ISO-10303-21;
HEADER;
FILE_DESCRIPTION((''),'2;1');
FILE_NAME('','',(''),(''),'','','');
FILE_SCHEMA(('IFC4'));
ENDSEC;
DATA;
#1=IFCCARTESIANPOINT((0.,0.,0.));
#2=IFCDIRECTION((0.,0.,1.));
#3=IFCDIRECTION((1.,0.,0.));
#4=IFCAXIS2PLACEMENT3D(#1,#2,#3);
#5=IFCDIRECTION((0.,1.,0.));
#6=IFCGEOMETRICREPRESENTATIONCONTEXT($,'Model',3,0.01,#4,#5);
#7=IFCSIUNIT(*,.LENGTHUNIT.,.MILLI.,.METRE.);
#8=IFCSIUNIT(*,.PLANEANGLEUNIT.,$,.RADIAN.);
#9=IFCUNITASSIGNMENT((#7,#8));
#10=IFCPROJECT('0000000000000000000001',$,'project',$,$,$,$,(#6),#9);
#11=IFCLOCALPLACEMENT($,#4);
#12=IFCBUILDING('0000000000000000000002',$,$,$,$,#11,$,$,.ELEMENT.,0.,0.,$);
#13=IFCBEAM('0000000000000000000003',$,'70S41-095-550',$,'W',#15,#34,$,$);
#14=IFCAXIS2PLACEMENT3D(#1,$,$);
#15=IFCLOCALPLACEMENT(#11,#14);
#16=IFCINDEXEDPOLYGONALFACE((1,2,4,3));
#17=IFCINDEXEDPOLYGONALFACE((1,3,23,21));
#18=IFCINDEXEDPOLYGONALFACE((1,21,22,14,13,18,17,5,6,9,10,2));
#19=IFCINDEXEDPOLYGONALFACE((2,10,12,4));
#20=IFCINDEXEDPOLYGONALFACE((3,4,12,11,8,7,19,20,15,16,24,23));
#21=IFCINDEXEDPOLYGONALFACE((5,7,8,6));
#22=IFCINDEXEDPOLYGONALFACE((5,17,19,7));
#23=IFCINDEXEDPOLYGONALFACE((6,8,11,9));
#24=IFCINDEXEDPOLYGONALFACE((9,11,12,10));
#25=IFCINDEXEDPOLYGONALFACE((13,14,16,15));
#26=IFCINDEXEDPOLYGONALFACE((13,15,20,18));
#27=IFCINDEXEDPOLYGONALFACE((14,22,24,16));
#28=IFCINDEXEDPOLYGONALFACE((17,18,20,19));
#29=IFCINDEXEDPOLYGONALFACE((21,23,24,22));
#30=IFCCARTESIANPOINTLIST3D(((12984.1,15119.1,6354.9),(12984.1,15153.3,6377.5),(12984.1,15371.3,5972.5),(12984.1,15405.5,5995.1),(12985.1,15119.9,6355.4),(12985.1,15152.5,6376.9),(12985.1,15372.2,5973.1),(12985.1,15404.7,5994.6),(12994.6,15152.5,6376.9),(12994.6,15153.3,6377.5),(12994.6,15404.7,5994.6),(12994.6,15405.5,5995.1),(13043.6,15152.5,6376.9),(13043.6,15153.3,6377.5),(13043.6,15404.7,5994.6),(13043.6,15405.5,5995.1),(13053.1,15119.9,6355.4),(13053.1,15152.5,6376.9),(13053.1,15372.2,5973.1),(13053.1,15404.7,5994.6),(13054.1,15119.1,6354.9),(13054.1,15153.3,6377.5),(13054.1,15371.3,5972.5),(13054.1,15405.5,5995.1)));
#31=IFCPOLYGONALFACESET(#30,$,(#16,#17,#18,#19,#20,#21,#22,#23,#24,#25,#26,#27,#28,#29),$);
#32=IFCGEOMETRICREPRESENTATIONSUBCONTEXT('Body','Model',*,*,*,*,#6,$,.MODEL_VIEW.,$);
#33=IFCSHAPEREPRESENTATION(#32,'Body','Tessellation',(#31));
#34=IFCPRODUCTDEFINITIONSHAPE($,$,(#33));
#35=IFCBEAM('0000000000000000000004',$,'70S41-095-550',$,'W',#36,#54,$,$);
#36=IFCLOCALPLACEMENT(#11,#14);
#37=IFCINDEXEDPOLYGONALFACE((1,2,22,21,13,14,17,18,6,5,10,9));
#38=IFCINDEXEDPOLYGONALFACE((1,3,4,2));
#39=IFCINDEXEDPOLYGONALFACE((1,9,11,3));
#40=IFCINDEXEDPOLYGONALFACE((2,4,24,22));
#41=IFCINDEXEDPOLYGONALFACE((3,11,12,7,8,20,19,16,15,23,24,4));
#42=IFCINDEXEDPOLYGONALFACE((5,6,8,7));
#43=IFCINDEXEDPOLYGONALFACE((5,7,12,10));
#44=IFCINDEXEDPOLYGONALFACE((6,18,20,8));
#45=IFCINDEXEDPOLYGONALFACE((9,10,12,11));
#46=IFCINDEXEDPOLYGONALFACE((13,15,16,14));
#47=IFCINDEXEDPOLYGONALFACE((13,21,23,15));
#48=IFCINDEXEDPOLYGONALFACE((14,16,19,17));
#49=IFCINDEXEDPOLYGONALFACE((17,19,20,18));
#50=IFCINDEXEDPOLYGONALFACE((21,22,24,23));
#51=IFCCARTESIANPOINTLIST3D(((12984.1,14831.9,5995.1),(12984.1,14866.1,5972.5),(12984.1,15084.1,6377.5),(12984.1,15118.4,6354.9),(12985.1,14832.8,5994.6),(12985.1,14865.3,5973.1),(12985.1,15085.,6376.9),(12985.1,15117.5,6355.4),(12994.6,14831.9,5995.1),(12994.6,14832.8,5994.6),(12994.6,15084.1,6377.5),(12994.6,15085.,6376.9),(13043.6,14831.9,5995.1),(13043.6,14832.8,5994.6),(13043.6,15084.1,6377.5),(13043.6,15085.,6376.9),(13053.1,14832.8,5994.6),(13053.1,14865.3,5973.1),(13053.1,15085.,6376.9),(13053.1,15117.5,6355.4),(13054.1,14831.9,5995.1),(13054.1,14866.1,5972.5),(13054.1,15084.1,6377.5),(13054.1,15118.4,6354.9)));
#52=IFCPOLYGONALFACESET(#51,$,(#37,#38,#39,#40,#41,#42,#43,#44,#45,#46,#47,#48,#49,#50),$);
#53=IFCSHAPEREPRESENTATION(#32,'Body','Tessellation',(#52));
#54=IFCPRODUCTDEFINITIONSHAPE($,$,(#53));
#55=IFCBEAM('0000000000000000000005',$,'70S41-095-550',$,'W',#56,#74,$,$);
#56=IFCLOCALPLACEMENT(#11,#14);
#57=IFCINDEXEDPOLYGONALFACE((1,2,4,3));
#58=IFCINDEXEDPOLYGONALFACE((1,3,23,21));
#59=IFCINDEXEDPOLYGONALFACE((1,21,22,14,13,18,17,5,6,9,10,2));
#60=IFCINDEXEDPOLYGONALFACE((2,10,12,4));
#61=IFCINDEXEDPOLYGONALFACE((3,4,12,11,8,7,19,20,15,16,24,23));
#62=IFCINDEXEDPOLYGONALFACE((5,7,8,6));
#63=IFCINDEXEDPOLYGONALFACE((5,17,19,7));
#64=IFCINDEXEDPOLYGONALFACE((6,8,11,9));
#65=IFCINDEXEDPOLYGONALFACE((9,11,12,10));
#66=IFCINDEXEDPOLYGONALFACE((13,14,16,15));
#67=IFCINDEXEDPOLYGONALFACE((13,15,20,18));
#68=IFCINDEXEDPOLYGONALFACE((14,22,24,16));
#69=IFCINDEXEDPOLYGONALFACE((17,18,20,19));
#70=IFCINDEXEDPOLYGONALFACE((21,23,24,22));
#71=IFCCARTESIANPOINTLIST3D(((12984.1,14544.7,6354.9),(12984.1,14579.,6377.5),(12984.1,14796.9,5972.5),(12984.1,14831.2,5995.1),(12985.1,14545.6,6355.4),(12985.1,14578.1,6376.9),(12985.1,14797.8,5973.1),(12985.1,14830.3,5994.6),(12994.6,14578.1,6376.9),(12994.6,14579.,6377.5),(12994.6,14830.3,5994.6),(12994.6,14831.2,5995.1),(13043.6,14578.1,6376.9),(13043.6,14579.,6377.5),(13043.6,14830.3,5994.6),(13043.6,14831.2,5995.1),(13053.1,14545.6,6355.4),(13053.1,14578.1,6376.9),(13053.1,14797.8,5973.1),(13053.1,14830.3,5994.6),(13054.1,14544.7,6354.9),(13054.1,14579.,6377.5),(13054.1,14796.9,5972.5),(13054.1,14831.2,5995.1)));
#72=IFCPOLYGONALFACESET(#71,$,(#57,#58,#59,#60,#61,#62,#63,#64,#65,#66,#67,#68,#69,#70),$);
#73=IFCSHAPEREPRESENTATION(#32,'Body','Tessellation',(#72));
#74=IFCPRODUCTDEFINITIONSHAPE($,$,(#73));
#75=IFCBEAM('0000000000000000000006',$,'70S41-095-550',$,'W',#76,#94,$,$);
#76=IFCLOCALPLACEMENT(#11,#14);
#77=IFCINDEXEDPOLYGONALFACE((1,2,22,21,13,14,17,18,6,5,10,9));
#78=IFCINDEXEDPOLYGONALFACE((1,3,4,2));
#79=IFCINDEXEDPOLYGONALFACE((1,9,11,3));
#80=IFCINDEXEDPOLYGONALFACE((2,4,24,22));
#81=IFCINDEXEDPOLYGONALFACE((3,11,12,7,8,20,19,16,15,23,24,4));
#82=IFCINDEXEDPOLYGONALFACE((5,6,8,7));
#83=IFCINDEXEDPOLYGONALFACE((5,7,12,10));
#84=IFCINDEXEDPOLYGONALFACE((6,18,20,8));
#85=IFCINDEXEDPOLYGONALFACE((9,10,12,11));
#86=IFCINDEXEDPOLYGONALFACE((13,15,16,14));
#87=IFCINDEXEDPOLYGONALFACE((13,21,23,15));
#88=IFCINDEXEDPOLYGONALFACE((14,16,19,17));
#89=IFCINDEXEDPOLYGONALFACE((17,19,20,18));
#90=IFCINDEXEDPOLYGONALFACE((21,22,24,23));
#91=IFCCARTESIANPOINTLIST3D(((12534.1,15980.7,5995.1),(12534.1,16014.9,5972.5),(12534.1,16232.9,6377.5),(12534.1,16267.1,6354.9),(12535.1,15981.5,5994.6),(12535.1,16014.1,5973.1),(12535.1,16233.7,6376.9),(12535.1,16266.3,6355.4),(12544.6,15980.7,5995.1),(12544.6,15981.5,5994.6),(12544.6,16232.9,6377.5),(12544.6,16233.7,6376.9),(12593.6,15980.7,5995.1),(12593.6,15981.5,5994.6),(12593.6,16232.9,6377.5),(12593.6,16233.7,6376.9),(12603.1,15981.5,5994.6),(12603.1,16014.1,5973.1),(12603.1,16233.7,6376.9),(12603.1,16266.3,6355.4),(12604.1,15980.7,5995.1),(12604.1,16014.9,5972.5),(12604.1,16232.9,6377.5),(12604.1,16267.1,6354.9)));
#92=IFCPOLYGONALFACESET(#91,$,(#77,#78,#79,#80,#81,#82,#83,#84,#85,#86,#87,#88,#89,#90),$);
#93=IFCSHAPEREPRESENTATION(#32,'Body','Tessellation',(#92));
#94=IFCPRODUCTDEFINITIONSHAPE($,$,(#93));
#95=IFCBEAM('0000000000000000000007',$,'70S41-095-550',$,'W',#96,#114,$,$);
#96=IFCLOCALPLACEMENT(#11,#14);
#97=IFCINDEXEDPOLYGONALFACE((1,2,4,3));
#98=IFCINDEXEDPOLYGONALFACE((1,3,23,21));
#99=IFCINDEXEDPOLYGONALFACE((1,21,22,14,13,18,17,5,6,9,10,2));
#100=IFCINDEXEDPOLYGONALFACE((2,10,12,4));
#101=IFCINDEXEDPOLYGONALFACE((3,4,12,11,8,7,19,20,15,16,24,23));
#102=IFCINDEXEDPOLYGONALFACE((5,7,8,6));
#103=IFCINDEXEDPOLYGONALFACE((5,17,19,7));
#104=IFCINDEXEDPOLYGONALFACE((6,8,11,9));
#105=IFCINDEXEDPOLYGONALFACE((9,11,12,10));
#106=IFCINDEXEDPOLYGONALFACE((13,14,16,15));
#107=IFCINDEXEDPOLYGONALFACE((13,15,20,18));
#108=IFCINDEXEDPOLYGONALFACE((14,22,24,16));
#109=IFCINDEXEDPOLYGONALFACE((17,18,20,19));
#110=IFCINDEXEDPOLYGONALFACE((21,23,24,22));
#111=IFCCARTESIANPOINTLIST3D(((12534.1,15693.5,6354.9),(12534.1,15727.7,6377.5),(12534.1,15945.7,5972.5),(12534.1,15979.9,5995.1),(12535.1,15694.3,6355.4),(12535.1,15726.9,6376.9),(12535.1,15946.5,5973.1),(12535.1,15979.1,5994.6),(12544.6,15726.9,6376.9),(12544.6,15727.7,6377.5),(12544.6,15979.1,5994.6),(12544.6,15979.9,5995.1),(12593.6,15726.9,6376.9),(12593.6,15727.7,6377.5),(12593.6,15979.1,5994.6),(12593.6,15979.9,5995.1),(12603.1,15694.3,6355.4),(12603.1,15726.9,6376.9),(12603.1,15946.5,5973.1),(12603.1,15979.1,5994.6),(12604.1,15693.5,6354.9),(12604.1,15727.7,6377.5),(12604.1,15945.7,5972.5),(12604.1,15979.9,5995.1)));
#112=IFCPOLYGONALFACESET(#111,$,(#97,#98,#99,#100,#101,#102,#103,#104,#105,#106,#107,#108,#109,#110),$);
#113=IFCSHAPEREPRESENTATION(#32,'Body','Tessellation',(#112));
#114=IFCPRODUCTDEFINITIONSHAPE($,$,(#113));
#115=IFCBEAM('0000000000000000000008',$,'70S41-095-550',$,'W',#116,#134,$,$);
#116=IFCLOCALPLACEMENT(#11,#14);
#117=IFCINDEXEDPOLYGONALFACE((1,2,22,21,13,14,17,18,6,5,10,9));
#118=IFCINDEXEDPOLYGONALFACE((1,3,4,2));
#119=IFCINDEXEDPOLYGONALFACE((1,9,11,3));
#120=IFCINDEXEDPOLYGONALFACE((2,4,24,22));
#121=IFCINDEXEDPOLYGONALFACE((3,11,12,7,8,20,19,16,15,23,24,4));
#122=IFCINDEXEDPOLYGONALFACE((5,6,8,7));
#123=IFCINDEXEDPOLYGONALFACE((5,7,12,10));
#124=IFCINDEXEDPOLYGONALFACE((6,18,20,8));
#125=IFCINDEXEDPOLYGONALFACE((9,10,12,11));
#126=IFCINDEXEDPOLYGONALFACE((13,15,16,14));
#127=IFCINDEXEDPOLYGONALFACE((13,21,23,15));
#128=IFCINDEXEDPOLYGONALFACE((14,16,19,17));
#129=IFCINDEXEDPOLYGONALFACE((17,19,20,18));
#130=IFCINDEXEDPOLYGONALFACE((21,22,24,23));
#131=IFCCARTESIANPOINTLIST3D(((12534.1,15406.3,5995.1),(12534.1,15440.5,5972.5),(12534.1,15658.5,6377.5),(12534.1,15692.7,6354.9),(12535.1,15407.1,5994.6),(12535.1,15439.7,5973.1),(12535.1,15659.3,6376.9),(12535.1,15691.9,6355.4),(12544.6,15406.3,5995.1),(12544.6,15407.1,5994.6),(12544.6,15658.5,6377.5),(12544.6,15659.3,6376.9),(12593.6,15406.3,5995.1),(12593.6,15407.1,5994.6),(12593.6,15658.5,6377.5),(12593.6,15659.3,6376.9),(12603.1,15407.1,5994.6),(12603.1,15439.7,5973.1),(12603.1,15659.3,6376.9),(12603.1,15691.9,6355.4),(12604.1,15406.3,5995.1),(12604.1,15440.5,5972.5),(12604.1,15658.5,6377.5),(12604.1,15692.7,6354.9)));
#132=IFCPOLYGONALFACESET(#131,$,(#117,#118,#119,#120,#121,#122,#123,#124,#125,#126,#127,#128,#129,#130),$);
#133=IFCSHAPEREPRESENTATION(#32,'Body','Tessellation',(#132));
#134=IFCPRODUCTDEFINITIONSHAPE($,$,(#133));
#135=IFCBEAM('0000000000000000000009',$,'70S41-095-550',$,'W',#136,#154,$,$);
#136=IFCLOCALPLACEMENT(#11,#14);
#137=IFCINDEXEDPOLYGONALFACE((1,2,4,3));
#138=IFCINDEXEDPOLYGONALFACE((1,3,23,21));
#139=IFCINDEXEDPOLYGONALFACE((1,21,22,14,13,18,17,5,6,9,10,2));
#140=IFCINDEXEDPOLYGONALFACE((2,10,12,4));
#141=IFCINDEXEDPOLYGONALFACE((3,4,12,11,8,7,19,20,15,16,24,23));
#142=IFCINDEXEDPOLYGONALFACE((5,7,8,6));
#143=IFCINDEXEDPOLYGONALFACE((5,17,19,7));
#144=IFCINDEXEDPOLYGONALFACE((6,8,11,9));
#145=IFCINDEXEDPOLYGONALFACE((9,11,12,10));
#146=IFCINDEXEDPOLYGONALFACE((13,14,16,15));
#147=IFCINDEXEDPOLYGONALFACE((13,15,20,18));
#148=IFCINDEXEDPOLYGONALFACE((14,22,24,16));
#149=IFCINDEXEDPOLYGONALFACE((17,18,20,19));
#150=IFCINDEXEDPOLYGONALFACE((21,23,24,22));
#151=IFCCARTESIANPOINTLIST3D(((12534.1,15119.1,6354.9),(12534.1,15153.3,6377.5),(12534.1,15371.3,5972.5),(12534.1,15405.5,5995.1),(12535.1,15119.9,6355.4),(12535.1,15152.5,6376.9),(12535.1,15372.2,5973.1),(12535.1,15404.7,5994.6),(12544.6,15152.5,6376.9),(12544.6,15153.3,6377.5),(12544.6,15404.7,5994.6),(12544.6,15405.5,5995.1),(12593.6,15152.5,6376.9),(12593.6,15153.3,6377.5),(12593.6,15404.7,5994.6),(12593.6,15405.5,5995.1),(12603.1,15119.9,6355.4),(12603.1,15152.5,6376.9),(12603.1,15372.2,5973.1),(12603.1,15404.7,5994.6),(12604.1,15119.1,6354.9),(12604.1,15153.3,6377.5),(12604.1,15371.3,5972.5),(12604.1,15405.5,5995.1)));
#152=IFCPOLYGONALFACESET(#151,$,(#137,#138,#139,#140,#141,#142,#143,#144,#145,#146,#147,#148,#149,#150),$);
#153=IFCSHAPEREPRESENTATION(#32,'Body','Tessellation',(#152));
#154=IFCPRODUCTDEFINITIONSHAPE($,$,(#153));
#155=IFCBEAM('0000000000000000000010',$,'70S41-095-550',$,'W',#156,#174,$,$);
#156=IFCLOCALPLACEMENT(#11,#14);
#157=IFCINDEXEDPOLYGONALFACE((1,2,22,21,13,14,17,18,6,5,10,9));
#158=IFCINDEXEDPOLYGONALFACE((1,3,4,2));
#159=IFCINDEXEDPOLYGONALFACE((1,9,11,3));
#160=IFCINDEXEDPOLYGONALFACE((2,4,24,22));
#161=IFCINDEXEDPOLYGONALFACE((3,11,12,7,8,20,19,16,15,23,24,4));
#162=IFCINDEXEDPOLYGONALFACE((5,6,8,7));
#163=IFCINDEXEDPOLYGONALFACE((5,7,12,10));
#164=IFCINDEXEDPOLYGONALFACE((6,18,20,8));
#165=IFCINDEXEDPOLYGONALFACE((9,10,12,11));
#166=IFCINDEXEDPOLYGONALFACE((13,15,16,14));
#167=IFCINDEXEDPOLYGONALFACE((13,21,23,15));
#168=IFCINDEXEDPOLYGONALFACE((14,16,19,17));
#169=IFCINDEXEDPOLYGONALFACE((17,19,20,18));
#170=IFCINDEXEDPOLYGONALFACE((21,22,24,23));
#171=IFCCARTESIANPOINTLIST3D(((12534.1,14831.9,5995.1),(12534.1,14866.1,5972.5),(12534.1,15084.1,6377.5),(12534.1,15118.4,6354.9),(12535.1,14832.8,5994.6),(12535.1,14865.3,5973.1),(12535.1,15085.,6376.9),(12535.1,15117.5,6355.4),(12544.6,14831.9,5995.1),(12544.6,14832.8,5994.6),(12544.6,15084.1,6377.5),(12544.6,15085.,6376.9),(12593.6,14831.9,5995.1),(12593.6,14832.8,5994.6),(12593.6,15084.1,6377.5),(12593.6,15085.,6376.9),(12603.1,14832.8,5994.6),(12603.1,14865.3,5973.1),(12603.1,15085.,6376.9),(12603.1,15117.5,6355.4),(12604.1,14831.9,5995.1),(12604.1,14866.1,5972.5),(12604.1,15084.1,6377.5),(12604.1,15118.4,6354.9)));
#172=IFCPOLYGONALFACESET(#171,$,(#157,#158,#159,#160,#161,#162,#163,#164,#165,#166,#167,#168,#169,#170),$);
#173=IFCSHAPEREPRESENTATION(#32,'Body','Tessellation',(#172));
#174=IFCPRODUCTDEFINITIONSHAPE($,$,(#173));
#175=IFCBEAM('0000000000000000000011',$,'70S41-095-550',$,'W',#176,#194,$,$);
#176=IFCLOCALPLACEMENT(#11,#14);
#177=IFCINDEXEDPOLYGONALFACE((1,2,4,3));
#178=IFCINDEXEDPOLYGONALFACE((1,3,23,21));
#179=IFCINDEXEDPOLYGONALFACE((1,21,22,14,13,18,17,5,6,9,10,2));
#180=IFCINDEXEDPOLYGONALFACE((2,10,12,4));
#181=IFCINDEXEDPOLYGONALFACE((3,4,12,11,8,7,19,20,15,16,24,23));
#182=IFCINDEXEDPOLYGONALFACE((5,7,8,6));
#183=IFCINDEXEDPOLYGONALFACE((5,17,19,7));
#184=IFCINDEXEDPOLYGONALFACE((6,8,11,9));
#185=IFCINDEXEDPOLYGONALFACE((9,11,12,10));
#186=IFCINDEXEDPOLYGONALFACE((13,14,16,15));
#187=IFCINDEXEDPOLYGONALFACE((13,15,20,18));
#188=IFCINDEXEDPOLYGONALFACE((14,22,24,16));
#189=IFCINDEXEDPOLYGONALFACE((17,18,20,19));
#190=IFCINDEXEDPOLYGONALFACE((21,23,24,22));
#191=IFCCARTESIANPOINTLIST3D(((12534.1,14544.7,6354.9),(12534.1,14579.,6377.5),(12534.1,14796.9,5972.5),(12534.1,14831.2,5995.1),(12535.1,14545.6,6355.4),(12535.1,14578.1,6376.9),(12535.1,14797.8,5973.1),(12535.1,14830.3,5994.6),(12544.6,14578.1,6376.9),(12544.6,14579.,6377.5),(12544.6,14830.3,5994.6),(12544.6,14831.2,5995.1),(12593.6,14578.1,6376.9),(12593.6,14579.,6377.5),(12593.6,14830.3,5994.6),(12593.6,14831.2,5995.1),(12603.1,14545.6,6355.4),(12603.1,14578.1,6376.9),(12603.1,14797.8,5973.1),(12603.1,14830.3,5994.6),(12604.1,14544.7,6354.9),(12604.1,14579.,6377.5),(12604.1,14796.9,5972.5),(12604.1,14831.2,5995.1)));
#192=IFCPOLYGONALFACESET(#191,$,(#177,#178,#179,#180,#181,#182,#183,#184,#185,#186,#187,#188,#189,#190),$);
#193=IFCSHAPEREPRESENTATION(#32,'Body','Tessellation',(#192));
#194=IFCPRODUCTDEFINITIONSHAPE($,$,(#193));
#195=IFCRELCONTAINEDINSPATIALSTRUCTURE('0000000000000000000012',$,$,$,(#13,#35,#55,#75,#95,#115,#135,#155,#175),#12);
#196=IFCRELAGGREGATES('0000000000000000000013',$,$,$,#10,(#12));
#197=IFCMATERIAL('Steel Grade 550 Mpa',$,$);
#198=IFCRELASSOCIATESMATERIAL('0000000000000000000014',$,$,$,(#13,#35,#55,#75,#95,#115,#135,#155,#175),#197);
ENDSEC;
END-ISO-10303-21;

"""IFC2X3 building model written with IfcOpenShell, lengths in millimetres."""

from ifc_helpers import new_model, si_unit, direction, frame, origin, origin_with_axes, origin_2d_with_axis, place, context, subcontext, project, spatial, c_section, extrude, source, transform, mapped, material, element, save


model = new_model("IFC2X3")

# Units and contexts
model_context = context("Model", 3, precision=0.01, world=origin_with_axes(), true_north=direction((0.0, 1.0, 0.0)))
body_context = subcontext(model_context, "Body", "Model", "MODEL_VIEW")
ifc_project = project(units=[si_unit("LENGTHUNIT", "METRE", prefix="MILLI"), si_unit("PLANEANGLEUNIT", "RADIAN")], contexts=[model_context])

# Building
building_placement = place(None, origin_with_axes())
building = spatial("IfcBuilding", under=ifc_project, at=building_placement, CompositionType="ELEMENT", ElevationOfRefHeight=0.0, ElevationOfTerrain=0.0)

# Beams
ifc_material = material(Name="Steel Grade 550 Mpa")
shared_shape_1 = source(origin(), body_context, "Body", "SweptSolid", [
    extrude(c_section(Depth=70.0, Width=41.0, WallThickness=1.0, Girth=10.5, at=origin_2d_with_axis()), origin_with_axes(), (0.0, 0.0, 1.0), 458.1),
])
beam_1_placement = place(None, frame((13019.1, 15136.2, 6366.2), z_axis=(0.0, 0.550611, -0.834762), x_axis=(0.0, 0.834762, 0.550611)))
element("IfcBeam", 1, at=beam_1_placement, inside=building, material=ifc_material, Name="70S41-095-550", ObjectType="W", context=body_context, shape_type="MappedRepresentation", body=[
    mapped(shared_shape_1, transform((0.0, 0.0, 0.0), scale=1.0)),
])
shared_shape_2 = source(origin(), body_context, "Body", "SweptSolid", [
    extrude(c_section(Depth=70.0, Width=41.0, WallThickness=1.0, Girth=10.5, at=origin_2d_with_axis()), origin_with_axes(), (0.0, 0.0, 1.0), 458.1),
])
beam_2_placement = place(None, frame((13019.1, 14849.0, 5983.8), z_axis=(0.0, 0.550611, 0.834762), x_axis=(0.0, -0.834762, 0.550611)))
element("IfcBeam", 2, at=beam_2_placement, inside=building, material=ifc_material, Name="70S41-095-550", ObjectType="W", context=body_context, shape_type="MappedRepresentation", body=[
    mapped(shared_shape_2, transform((0.0, 0.0, 0.0), scale=1.0)),
])
shared_shape_3 = source(origin(), body_context, "Body", "SweptSolid", [
    extrude(c_section(Depth=70.0, Width=41.0, WallThickness=1.0, Girth=10.5, at=origin_2d_with_axis()), origin_with_axes(), (0.0, 0.0, 1.0), 458.1),
])
beam_3_placement = place(None, frame((13019.1, 14561.8, 6366.2), z_axis=(0.0, 0.550611, -0.834762), x_axis=(0.0, 0.834762, 0.550611)))
element("IfcBeam", 3, at=beam_3_placement, inside=building, material=ifc_material, Name="70S41-095-550", ObjectType="W", context=body_context, shape_type="MappedRepresentation", body=[
    mapped(shared_shape_3, transform((0.0, 0.0, 0.0), scale=1.0)),
])
shared_shape_4 = source(origin(), body_context, "Body", "SweptSolid", [
    extrude(c_section(Depth=70.0, Width=41.0, WallThickness=1.0, Girth=10.5, at=origin_2d_with_axis()), origin_with_axes(), (0.0, 0.0, 1.0), 458.1),
])
beam_4_placement = place(None, frame((12569.1, 15997.8, 5983.8), z_axis=(0.0, 0.550611, 0.834762), x_axis=(0.0, -0.834762, 0.550611)))
element("IfcBeam", 4, at=beam_4_placement, inside=building, material=ifc_material, Name="70S41-095-550", ObjectType="W", context=body_context, shape_type="MappedRepresentation", body=[
    mapped(shared_shape_4, transform((0.0, 0.0, 0.0), scale=1.0)),
])
shared_shape_5 = source(origin(), body_context, "Body", "SweptSolid", [
    extrude(c_section(Depth=70.0, Width=41.0, WallThickness=1.0, Girth=10.5, at=origin_2d_with_axis()), origin_with_axes(), (0.0, 0.0, 1.0), 458.1),
])
beam_5_placement = place(None, frame((12569.1, 15710.6, 6366.2), z_axis=(0.0, 0.550611, -0.834762), x_axis=(0.0, 0.834762, 0.550611)))
element("IfcBeam", 5, at=beam_5_placement, inside=building, material=ifc_material, Name="70S41-095-550", ObjectType="W", context=body_context, shape_type="MappedRepresentation", body=[
    mapped(shared_shape_5, transform((0.0, 0.0, 0.0), scale=1.0)),
])
shared_shape_6 = source(origin(), body_context, "Body", "SweptSolid", [
    extrude(c_section(Depth=70.0, Width=41.0, WallThickness=1.0, Girth=10.5, at=origin_2d_with_axis()), origin_with_axes(), (0.0, 0.0, 1.0), 458.1),
])
beam_6_placement = place(None, frame((12569.1, 15423.4, 5983.8), z_axis=(0.0, 0.550611, 0.834762), x_axis=(0.0, -0.834762, 0.550611)))
element("IfcBeam", 6, at=beam_6_placement, inside=building, material=ifc_material, Name="70S41-095-550", ObjectType="W", context=body_context, shape_type="MappedRepresentation", body=[
    mapped(shared_shape_6, transform((0.0, 0.0, 0.0), scale=1.0)),
])
shared_shape_7 = source(origin(), body_context, "Body", "SweptSolid", [
    extrude(c_section(Depth=70.0, Width=41.0, WallThickness=1.0, Girth=10.5, at=origin_2d_with_axis()), origin_with_axes(), (0.0, 0.0, 1.0), 458.1),
])
beam_7_placement = place(None, frame((12569.1, 15136.2, 6366.2), z_axis=(0.0, 0.550611, -0.834762), x_axis=(0.0, 0.834762, 0.550611)))
element("IfcBeam", 7, at=beam_7_placement, inside=building, material=ifc_material, Name="70S41-095-550", ObjectType="W", context=body_context, shape_type="MappedRepresentation", body=[
    mapped(shared_shape_7, transform((0.0, 0.0, 0.0), scale=1.0)),
])
shared_shape_8 = source(origin(), body_context, "Body", "SweptSolid", [
    extrude(c_section(Depth=70.0, Width=41.0, WallThickness=1.0, Girth=10.5, at=origin_2d_with_axis()), origin_with_axes(), (0.0, 0.0, 1.0), 458.1),
])
beam_8_placement = place(None, frame((12569.1, 14849.0, 5983.8), z_axis=(0.0, 0.550611, 0.834762), x_axis=(0.0, -0.834762, 0.550611)))
element("IfcBeam", 8, at=beam_8_placement, inside=building, material=ifc_material, Name="70S41-095-550", ObjectType="W", context=body_context, shape_type="MappedRepresentation", body=[
    mapped(shared_shape_8, transform((0.0, 0.0, 0.0), scale=1.0)),
])
shared_shape_9 = source(origin(), body_context, "Body", "SweptSolid", [
    extrude(c_section(Depth=70.0, Width=41.0, WallThickness=1.0, Girth=10.5, at=origin_2d_with_axis()), origin_with_axes(), (0.0, 0.0, 1.0), 458.1),
])
beam_9_placement = place(None, frame((12569.1, 14561.8, 6366.2), z_axis=(0.0, 0.550611, -0.834762), x_axis=(0.0, 0.834762, 0.550611)))
element("IfcBeam", 9, at=beam_9_placement, inside=building, material=ifc_material, Name="70S41-095-550", ObjectType="W", context=body_context, shape_type="MappedRepresentation", body=[
    mapped(shared_shape_9, transform((0.0, 0.0, 0.0), scale=1.0)),
])

save(model, "model.ifc")
